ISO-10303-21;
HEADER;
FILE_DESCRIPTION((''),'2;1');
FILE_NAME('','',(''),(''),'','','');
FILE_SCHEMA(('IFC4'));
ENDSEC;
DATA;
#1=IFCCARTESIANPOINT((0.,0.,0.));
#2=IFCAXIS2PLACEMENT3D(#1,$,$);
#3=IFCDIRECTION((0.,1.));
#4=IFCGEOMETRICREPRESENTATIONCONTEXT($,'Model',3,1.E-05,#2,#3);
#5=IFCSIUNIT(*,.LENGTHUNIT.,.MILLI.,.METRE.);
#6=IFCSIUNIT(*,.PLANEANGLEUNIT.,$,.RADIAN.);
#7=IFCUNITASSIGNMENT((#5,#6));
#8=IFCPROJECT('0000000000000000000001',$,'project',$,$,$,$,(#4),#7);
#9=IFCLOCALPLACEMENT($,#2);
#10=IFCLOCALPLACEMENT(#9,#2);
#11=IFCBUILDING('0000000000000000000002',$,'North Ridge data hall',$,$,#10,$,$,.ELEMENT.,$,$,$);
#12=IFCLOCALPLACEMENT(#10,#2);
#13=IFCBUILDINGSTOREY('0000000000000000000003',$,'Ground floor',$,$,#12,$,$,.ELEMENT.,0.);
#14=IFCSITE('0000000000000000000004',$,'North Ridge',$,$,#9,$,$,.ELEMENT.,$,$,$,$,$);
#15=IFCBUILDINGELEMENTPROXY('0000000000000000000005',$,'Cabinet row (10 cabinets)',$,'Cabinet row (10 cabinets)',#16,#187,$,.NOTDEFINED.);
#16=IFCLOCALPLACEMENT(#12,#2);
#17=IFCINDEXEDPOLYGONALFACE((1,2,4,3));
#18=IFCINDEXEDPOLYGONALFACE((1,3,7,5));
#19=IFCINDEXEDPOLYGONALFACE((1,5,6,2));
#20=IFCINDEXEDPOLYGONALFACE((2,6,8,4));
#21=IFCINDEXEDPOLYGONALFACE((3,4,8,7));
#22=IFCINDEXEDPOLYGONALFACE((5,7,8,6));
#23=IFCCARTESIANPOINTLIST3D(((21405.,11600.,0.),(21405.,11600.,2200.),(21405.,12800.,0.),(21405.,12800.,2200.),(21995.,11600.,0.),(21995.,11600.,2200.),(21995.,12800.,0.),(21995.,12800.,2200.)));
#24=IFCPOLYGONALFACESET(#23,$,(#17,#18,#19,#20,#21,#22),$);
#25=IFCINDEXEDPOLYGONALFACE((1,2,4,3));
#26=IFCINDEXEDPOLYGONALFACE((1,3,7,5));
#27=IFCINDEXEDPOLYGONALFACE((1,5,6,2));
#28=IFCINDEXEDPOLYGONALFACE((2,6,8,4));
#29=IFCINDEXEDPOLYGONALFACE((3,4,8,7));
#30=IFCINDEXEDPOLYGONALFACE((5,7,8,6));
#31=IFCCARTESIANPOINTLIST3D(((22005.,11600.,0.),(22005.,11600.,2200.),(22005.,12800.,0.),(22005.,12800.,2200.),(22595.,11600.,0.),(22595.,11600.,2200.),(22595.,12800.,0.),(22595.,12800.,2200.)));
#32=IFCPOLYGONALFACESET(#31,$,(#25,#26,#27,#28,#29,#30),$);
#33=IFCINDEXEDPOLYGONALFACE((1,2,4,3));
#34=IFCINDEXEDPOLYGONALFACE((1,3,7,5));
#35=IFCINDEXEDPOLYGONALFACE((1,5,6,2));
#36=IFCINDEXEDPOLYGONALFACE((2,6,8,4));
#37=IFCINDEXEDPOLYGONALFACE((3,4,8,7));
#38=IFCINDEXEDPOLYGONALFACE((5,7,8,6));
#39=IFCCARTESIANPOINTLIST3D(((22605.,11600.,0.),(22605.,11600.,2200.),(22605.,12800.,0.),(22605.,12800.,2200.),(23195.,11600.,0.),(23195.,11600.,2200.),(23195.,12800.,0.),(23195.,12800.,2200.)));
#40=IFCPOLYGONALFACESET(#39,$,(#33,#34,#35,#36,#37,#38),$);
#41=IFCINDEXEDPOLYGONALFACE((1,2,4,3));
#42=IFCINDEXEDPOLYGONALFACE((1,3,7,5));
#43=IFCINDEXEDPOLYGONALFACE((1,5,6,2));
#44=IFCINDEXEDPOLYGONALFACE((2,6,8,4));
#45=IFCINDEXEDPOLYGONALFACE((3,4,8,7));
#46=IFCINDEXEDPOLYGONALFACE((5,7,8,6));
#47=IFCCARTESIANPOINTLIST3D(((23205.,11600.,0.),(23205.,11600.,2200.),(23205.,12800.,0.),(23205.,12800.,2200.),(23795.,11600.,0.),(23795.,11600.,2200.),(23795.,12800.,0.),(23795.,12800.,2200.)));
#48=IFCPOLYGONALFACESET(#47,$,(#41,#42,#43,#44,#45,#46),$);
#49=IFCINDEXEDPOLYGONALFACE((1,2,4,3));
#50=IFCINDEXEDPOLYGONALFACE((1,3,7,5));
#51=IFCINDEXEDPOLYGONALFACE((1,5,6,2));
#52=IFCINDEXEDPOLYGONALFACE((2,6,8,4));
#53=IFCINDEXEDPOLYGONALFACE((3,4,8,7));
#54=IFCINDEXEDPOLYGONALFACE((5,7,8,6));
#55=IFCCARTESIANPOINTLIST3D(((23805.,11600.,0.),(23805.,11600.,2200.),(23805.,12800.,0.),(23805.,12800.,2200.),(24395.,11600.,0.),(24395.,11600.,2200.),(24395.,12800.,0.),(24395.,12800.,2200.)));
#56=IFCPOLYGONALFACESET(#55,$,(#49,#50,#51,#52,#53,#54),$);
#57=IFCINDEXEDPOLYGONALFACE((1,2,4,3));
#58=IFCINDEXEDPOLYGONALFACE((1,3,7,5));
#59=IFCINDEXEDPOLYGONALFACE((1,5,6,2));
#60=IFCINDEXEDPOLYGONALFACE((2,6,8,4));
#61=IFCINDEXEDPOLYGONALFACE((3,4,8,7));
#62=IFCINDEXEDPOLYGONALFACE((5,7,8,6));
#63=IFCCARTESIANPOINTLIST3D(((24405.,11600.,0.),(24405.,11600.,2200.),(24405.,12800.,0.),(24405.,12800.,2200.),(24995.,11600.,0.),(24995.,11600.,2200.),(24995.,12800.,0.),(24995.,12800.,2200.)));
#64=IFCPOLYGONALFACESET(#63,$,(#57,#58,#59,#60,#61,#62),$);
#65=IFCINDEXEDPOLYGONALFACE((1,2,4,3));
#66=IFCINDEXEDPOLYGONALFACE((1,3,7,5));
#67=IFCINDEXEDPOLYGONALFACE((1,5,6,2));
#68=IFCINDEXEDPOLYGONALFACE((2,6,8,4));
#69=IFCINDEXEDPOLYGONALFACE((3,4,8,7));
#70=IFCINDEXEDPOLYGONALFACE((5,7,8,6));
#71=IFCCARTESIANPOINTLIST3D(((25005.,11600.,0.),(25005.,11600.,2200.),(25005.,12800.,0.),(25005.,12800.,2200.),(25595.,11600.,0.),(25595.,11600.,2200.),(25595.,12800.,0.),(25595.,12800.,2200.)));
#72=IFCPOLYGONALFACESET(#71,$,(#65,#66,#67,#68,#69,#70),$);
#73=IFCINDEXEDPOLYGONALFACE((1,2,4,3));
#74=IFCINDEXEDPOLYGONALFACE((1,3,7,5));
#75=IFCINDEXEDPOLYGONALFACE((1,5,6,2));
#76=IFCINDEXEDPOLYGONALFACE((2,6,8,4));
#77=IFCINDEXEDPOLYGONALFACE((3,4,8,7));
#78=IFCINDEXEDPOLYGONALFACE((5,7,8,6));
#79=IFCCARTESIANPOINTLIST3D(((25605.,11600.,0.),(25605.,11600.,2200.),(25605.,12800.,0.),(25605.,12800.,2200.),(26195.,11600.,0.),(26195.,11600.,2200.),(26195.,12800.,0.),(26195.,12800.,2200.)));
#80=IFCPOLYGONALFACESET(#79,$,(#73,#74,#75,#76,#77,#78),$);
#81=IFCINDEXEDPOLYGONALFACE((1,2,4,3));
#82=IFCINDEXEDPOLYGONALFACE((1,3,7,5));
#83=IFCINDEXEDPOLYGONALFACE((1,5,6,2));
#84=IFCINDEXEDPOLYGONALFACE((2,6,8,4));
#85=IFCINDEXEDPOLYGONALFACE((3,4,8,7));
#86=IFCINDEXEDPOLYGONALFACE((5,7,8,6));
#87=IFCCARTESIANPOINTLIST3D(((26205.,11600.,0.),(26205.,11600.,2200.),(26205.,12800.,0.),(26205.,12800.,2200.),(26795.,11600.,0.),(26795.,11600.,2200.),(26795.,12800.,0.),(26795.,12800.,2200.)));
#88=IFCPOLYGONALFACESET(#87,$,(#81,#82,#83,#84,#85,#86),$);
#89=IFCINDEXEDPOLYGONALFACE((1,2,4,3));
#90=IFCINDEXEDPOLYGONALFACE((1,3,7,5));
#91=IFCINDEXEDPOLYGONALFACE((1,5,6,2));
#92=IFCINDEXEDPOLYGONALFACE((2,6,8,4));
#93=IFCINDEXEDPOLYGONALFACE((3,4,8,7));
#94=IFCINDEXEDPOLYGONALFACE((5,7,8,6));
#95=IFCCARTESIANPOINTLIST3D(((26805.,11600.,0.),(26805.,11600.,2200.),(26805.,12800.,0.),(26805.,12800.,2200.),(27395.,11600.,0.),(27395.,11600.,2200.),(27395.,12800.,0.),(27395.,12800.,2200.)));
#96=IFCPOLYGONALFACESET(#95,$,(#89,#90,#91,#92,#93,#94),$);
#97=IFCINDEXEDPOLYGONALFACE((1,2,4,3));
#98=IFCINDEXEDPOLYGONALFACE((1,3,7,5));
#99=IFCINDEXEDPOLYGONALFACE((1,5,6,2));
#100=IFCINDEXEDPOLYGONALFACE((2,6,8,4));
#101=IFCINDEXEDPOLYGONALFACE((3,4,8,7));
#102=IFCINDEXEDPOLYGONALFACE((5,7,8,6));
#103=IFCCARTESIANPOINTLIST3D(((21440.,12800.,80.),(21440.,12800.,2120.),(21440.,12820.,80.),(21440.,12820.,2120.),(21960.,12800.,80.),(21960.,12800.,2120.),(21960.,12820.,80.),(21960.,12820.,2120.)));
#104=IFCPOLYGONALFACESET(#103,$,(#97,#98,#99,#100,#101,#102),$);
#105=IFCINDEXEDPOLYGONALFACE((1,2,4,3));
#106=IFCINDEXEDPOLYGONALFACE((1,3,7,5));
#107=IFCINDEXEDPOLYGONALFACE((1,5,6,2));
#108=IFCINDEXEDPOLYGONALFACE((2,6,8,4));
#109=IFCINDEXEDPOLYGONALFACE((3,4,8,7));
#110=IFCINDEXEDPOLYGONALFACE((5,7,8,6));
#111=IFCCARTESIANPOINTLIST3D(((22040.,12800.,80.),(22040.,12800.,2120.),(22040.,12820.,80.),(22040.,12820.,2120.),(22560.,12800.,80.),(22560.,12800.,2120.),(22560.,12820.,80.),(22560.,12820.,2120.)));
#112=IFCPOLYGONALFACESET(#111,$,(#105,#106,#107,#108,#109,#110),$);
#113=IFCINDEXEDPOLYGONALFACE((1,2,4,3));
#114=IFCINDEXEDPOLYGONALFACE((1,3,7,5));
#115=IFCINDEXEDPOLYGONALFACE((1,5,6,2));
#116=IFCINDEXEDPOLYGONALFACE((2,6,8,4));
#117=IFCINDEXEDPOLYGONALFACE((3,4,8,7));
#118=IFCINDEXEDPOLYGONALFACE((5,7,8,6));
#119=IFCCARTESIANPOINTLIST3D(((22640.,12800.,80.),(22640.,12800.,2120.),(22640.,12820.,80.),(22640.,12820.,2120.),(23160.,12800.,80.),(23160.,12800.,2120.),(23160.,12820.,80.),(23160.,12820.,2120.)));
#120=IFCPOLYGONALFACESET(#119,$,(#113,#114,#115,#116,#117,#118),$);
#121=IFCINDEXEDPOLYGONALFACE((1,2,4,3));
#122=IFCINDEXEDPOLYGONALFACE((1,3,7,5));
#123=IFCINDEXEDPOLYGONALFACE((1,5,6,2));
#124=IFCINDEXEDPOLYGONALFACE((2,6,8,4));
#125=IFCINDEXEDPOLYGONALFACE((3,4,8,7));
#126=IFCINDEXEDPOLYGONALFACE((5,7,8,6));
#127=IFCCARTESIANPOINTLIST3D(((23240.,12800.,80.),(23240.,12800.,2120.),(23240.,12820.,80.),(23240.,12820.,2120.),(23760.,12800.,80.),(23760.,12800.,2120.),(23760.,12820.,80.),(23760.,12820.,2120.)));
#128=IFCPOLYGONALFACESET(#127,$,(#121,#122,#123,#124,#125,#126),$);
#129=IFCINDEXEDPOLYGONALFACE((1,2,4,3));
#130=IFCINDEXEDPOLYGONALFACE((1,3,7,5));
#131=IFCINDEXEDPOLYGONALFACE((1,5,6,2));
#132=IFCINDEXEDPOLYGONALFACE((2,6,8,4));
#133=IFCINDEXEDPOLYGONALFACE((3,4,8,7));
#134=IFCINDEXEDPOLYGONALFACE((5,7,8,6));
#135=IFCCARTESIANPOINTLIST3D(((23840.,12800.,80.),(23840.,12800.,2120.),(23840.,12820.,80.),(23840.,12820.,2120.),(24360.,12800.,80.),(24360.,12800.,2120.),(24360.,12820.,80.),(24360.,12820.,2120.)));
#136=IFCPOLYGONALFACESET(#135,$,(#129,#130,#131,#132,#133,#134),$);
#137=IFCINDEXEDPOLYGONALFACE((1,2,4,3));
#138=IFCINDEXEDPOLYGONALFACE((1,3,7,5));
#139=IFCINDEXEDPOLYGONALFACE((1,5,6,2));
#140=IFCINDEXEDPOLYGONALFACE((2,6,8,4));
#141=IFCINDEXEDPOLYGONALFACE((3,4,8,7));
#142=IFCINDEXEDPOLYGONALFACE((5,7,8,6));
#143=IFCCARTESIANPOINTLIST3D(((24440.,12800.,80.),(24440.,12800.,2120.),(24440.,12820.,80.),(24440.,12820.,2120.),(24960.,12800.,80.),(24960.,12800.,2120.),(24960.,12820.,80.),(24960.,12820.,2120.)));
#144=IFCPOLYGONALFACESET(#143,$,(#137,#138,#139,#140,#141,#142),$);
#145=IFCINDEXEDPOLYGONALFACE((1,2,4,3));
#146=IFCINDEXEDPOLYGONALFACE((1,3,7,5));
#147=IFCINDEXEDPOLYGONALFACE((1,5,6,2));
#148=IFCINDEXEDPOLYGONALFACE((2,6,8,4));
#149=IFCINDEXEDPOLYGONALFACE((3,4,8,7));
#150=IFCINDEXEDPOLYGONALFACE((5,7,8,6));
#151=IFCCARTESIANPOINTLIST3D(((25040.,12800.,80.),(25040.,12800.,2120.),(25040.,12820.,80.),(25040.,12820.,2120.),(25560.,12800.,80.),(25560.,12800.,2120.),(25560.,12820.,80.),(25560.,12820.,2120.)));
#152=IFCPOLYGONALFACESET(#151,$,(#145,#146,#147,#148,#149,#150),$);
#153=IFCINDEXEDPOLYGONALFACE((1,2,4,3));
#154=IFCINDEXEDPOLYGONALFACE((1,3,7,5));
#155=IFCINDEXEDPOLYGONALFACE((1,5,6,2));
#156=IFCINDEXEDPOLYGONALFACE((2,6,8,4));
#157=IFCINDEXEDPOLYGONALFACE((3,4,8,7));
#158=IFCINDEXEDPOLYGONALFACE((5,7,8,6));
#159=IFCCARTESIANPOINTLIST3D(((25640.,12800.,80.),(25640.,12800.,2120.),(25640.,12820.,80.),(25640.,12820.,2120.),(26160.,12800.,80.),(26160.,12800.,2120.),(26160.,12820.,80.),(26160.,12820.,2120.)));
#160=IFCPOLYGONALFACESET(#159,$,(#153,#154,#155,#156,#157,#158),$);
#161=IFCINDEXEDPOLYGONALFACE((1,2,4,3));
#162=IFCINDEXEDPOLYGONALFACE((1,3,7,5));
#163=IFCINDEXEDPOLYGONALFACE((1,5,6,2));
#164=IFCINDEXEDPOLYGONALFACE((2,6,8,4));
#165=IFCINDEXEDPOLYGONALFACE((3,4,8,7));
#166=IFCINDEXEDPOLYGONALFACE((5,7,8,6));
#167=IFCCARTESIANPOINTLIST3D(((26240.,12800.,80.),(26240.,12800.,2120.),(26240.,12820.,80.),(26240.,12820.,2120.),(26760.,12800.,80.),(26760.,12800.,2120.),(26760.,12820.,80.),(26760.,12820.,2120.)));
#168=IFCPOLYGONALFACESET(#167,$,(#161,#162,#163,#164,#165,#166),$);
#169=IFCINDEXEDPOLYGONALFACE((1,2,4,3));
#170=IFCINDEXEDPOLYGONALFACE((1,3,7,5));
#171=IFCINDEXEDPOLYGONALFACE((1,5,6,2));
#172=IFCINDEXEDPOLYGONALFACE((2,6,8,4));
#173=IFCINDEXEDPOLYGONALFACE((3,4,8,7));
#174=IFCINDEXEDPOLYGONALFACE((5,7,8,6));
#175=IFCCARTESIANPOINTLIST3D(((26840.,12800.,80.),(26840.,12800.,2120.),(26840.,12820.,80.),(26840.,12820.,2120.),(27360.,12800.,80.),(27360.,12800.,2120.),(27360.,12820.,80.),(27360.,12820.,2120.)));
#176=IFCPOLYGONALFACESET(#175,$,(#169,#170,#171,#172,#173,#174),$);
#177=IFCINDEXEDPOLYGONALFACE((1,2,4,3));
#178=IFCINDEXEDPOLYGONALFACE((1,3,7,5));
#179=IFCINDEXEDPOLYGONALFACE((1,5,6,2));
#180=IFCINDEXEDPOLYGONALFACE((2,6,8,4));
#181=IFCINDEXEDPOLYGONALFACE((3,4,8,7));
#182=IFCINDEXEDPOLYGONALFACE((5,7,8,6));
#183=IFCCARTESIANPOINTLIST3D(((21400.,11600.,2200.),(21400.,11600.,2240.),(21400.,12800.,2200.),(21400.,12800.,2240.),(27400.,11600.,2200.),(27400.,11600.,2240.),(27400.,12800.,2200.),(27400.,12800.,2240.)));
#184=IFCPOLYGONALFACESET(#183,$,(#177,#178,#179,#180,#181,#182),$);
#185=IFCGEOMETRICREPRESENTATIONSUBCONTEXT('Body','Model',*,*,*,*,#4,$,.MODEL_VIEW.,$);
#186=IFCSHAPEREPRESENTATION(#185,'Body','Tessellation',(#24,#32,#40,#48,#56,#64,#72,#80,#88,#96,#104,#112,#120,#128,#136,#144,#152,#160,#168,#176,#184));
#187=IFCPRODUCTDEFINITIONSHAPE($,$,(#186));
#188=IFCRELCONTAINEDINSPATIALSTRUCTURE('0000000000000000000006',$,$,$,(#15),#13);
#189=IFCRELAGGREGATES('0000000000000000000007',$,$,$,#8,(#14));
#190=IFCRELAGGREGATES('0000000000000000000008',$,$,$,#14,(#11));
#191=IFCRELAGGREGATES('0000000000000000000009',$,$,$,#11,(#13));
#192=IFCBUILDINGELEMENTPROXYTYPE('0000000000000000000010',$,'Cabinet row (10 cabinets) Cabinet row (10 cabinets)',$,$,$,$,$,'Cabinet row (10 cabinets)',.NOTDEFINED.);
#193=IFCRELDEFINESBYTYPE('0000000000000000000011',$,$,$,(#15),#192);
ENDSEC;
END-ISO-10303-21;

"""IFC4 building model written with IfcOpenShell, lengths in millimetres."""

from ifc_helpers import new_model, si_unit, direction, frame, origin, place, context, subcontext, project, spatial, polyline, outline, extrude, source, transform, mapped, type_object, type_shapes, element, save


model = new_model("IFC4")

# Units and contexts
model_context = context("Model", 3, precision=1e-05, world=origin(), true_north=direction((0.0, 1.0)))
body_context = subcontext(model_context, "Body", "Model", "MODEL_VIEW")
ifc_project = project(units=[si_unit("LENGTHUNIT", "METRE", prefix="MILLI"), si_unit("PLANEANGLEUNIT", "RADIAN")], contexts=[model_context])

# Site, building, storey
site_placement = place(None, origin())
site = spatial("IfcSite", under=ifc_project, at=site_placement, Name="North Ridge", CompositionType="ELEMENT")
building_placement = place(site_placement, origin())
building = spatial("IfcBuilding", under=site, at=building_placement, Name="North Ridge data hall", CompositionType="ELEMENT")
storey_placement = place(building_placement, origin())
storey = spatial("IfcBuildingStorey", under=building, at=storey_placement, Name="Ground floor", CompositionType="ELEMENT", Elevation=0.0)

# Building element proxy
building_element_proxy_type_1 = type_object("IfcBuildingElementProxyType", Name="Cabinet row (10 cabinets) Cabinet row (10 cabinets)", ElementType="Cabinet row (10 cabinets)", PredefinedType="NOTDEFINED")
shared_shape_1 = source(origin(), body_context, "Body", "SweptSolid", [
    extrude(outline(polyline([(5.0, 0.0), (595.0, 0.0), (595.0, 1200.0), (5.0, 1200.0), (5.0, 0.0)])), origin(), (0.0, 0.0, 1.0), 2200.0),
    extrude(outline(polyline([(605.0, 0.0), (1195.0, 0.0), (1195.0, 1200.0), (605.0, 1200.0), (605.0, 0.0)])), origin(), (0.0, 0.0, 1.0), 2200.0),
    extrude(outline(polyline([(1205.0, 0.0), (1795.0, 0.0), (1795.0, 1200.0), (1205.0, 1200.0), (1205.0, 0.0)])), origin(), (0.0, 0.0, 1.0), 2200.0),
    extrude(outline(polyline([(1805.0, 0.0), (2395.0, 0.0), (2395.0, 1200.0), (1805.0, 1200.0), (1805.0, 0.0)])), origin(), (0.0, 0.0, 1.0), 2200.0),
    extrude(outline(polyline([(2405.0, 0.0), (2995.0, 0.0), (2995.0, 1200.0), (2405.0, 1200.0), (2405.0, 0.0)])), origin(), (0.0, 0.0, 1.0), 2200.0),
    extrude(outline(polyline([(3005.0, 0.0), (3595.0, 0.0), (3595.0, 1200.0), (3005.0, 1200.0), (3005.0, 0.0)])), origin(), (0.0, 0.0, 1.0), 2200.0),
    extrude(outline(polyline([(3605.0, 0.0), (4195.0, 0.0), (4195.0, 1200.0), (3605.0, 1200.0), (3605.0, 0.0)])), origin(), (0.0, 0.0, 1.0), 2200.0),
    extrude(outline(polyline([(4205.0, 0.0), (4795.0, 0.0), (4795.0, 1200.0), (4205.0, 1200.0), (4205.0, 0.0)])), origin(), (0.0, 0.0, 1.0), 2200.0),
    extrude(outline(polyline([(4805.0, 0.0), (5395.0, 0.0), (5395.0, 1200.0), (4805.0, 1200.0), (4805.0, 0.0)])), origin(), (0.0, 0.0, 1.0), 2200.0),
    extrude(outline(polyline([(5405.0, 0.0), (5995.0, 0.0), (5995.0, 1200.0), (5405.0, 1200.0), (5405.0, 0.0)])), origin(), (0.0, 0.0, 1.0), 2200.0),
    extrude(outline(polyline([(40.0, 1200.0), (560.0, 1200.0), (560.0, 1220.0), (40.0, 1220.0), (40.0, 1200.0)])), frame((0.0, 0.0, 80.0)), (0.0, 0.0, 1.0), 2040.0),
    extrude(outline(polyline([(640.0, 1200.0), (1160.0, 1200.0), (1160.0, 1220.0), (640.0, 1220.0), (640.0, 1200.0)])), frame((0.0, 0.0, 80.0)), (0.0, 0.0, 1.0), 2040.0),
    extrude(outline(polyline([(1240.0, 1200.0), (1760.0, 1200.0), (1760.0, 1220.0), (1240.0, 1220.0), (1240.0, 1200.0)])), frame((0.0, 0.0, 80.0)), (0.0, 0.0, 1.0), 2040.0),
    extrude(outline(polyline([(1840.0, 1200.0), (2360.0, 1200.0), (2360.0, 1220.0), (1840.0, 1220.0), (1840.0, 1200.0)])), frame((0.0, 0.0, 80.0)), (0.0, 0.0, 1.0), 2040.0),
    extrude(outline(polyline([(2440.0, 1200.0), (2960.0, 1200.0), (2960.0, 1220.0), (2440.0, 1220.0), (2440.0, 1200.0)])), frame((0.0, 0.0, 80.0)), (0.0, 0.0, 1.0), 2040.0),
    extrude(outline(polyline([(3040.0, 1200.0), (3560.0, 1200.0), (3560.0, 1220.0), (3040.0, 1220.0), (3040.0, 1200.0)])), frame((0.0, 0.0, 80.0)), (0.0, 0.0, 1.0), 2040.0),
    extrude(outline(polyline([(3640.0, 1200.0), (4160.0, 1200.0), (4160.0, 1220.0), (3640.0, 1220.0), (3640.0, 1200.0)])), frame((0.0, 0.0, 80.0)), (0.0, 0.0, 1.0), 2040.0),
    extrude(outline(polyline([(4240.0, 1200.0), (4760.0, 1200.0), (4760.0, 1220.0), (4240.0, 1220.0), (4240.0, 1200.0)])), frame((0.0, 0.0, 80.0)), (0.0, 0.0, 1.0), 2040.0),
    extrude(outline(polyline([(4840.0, 1200.0), (5360.0, 1200.0), (5360.0, 1220.0), (4840.0, 1220.0), (4840.0, 1200.0)])), frame((0.0, 0.0, 80.0)), (0.0, 0.0, 1.0), 2040.0),
    extrude(outline(polyline([(5440.0, 1200.0), (5960.0, 1200.0), (5960.0, 1220.0), (5440.0, 1220.0), (5440.0, 1200.0)])), frame((0.0, 0.0, 80.0)), (0.0, 0.0, 1.0), 2040.0),
    extrude(outline(polyline([(0.0, 0.0), (6000.0, 0.0), (6000.0, 1200.0), (0.0, 1200.0), (0.0, 0.0)])), frame((0.0, 0.0, 2200.0)), (0.0, 0.0, 1.0), 40.0),
])
type_shapes(building_element_proxy_type_1, [shared_shape_1])
for number, where, z_axis, x_axis, name in (
    (1, (21400.0, 11600.0, 0.0), (0.0, 0.0, 1.0), (1.0, 0.0, 0.0), "Cabinet row (10 cabinets)"),
):
    element("IfcBuildingElementProxy", number, at=place(storey_placement, frame(where, z_axis=z_axis, x_axis=x_axis)), inside=storey, type_object=building_element_proxy_type_1, Name=name, ObjectType="Cabinet row (10 cabinets)", PredefinedType="NOTDEFINED", context=body_context, shape_type="MappedRepresentation", body=[
        mapped(shared_shape_1, transform((0.0, 0.0, 0.0))),
    ])

save(model, "model.ifc")
